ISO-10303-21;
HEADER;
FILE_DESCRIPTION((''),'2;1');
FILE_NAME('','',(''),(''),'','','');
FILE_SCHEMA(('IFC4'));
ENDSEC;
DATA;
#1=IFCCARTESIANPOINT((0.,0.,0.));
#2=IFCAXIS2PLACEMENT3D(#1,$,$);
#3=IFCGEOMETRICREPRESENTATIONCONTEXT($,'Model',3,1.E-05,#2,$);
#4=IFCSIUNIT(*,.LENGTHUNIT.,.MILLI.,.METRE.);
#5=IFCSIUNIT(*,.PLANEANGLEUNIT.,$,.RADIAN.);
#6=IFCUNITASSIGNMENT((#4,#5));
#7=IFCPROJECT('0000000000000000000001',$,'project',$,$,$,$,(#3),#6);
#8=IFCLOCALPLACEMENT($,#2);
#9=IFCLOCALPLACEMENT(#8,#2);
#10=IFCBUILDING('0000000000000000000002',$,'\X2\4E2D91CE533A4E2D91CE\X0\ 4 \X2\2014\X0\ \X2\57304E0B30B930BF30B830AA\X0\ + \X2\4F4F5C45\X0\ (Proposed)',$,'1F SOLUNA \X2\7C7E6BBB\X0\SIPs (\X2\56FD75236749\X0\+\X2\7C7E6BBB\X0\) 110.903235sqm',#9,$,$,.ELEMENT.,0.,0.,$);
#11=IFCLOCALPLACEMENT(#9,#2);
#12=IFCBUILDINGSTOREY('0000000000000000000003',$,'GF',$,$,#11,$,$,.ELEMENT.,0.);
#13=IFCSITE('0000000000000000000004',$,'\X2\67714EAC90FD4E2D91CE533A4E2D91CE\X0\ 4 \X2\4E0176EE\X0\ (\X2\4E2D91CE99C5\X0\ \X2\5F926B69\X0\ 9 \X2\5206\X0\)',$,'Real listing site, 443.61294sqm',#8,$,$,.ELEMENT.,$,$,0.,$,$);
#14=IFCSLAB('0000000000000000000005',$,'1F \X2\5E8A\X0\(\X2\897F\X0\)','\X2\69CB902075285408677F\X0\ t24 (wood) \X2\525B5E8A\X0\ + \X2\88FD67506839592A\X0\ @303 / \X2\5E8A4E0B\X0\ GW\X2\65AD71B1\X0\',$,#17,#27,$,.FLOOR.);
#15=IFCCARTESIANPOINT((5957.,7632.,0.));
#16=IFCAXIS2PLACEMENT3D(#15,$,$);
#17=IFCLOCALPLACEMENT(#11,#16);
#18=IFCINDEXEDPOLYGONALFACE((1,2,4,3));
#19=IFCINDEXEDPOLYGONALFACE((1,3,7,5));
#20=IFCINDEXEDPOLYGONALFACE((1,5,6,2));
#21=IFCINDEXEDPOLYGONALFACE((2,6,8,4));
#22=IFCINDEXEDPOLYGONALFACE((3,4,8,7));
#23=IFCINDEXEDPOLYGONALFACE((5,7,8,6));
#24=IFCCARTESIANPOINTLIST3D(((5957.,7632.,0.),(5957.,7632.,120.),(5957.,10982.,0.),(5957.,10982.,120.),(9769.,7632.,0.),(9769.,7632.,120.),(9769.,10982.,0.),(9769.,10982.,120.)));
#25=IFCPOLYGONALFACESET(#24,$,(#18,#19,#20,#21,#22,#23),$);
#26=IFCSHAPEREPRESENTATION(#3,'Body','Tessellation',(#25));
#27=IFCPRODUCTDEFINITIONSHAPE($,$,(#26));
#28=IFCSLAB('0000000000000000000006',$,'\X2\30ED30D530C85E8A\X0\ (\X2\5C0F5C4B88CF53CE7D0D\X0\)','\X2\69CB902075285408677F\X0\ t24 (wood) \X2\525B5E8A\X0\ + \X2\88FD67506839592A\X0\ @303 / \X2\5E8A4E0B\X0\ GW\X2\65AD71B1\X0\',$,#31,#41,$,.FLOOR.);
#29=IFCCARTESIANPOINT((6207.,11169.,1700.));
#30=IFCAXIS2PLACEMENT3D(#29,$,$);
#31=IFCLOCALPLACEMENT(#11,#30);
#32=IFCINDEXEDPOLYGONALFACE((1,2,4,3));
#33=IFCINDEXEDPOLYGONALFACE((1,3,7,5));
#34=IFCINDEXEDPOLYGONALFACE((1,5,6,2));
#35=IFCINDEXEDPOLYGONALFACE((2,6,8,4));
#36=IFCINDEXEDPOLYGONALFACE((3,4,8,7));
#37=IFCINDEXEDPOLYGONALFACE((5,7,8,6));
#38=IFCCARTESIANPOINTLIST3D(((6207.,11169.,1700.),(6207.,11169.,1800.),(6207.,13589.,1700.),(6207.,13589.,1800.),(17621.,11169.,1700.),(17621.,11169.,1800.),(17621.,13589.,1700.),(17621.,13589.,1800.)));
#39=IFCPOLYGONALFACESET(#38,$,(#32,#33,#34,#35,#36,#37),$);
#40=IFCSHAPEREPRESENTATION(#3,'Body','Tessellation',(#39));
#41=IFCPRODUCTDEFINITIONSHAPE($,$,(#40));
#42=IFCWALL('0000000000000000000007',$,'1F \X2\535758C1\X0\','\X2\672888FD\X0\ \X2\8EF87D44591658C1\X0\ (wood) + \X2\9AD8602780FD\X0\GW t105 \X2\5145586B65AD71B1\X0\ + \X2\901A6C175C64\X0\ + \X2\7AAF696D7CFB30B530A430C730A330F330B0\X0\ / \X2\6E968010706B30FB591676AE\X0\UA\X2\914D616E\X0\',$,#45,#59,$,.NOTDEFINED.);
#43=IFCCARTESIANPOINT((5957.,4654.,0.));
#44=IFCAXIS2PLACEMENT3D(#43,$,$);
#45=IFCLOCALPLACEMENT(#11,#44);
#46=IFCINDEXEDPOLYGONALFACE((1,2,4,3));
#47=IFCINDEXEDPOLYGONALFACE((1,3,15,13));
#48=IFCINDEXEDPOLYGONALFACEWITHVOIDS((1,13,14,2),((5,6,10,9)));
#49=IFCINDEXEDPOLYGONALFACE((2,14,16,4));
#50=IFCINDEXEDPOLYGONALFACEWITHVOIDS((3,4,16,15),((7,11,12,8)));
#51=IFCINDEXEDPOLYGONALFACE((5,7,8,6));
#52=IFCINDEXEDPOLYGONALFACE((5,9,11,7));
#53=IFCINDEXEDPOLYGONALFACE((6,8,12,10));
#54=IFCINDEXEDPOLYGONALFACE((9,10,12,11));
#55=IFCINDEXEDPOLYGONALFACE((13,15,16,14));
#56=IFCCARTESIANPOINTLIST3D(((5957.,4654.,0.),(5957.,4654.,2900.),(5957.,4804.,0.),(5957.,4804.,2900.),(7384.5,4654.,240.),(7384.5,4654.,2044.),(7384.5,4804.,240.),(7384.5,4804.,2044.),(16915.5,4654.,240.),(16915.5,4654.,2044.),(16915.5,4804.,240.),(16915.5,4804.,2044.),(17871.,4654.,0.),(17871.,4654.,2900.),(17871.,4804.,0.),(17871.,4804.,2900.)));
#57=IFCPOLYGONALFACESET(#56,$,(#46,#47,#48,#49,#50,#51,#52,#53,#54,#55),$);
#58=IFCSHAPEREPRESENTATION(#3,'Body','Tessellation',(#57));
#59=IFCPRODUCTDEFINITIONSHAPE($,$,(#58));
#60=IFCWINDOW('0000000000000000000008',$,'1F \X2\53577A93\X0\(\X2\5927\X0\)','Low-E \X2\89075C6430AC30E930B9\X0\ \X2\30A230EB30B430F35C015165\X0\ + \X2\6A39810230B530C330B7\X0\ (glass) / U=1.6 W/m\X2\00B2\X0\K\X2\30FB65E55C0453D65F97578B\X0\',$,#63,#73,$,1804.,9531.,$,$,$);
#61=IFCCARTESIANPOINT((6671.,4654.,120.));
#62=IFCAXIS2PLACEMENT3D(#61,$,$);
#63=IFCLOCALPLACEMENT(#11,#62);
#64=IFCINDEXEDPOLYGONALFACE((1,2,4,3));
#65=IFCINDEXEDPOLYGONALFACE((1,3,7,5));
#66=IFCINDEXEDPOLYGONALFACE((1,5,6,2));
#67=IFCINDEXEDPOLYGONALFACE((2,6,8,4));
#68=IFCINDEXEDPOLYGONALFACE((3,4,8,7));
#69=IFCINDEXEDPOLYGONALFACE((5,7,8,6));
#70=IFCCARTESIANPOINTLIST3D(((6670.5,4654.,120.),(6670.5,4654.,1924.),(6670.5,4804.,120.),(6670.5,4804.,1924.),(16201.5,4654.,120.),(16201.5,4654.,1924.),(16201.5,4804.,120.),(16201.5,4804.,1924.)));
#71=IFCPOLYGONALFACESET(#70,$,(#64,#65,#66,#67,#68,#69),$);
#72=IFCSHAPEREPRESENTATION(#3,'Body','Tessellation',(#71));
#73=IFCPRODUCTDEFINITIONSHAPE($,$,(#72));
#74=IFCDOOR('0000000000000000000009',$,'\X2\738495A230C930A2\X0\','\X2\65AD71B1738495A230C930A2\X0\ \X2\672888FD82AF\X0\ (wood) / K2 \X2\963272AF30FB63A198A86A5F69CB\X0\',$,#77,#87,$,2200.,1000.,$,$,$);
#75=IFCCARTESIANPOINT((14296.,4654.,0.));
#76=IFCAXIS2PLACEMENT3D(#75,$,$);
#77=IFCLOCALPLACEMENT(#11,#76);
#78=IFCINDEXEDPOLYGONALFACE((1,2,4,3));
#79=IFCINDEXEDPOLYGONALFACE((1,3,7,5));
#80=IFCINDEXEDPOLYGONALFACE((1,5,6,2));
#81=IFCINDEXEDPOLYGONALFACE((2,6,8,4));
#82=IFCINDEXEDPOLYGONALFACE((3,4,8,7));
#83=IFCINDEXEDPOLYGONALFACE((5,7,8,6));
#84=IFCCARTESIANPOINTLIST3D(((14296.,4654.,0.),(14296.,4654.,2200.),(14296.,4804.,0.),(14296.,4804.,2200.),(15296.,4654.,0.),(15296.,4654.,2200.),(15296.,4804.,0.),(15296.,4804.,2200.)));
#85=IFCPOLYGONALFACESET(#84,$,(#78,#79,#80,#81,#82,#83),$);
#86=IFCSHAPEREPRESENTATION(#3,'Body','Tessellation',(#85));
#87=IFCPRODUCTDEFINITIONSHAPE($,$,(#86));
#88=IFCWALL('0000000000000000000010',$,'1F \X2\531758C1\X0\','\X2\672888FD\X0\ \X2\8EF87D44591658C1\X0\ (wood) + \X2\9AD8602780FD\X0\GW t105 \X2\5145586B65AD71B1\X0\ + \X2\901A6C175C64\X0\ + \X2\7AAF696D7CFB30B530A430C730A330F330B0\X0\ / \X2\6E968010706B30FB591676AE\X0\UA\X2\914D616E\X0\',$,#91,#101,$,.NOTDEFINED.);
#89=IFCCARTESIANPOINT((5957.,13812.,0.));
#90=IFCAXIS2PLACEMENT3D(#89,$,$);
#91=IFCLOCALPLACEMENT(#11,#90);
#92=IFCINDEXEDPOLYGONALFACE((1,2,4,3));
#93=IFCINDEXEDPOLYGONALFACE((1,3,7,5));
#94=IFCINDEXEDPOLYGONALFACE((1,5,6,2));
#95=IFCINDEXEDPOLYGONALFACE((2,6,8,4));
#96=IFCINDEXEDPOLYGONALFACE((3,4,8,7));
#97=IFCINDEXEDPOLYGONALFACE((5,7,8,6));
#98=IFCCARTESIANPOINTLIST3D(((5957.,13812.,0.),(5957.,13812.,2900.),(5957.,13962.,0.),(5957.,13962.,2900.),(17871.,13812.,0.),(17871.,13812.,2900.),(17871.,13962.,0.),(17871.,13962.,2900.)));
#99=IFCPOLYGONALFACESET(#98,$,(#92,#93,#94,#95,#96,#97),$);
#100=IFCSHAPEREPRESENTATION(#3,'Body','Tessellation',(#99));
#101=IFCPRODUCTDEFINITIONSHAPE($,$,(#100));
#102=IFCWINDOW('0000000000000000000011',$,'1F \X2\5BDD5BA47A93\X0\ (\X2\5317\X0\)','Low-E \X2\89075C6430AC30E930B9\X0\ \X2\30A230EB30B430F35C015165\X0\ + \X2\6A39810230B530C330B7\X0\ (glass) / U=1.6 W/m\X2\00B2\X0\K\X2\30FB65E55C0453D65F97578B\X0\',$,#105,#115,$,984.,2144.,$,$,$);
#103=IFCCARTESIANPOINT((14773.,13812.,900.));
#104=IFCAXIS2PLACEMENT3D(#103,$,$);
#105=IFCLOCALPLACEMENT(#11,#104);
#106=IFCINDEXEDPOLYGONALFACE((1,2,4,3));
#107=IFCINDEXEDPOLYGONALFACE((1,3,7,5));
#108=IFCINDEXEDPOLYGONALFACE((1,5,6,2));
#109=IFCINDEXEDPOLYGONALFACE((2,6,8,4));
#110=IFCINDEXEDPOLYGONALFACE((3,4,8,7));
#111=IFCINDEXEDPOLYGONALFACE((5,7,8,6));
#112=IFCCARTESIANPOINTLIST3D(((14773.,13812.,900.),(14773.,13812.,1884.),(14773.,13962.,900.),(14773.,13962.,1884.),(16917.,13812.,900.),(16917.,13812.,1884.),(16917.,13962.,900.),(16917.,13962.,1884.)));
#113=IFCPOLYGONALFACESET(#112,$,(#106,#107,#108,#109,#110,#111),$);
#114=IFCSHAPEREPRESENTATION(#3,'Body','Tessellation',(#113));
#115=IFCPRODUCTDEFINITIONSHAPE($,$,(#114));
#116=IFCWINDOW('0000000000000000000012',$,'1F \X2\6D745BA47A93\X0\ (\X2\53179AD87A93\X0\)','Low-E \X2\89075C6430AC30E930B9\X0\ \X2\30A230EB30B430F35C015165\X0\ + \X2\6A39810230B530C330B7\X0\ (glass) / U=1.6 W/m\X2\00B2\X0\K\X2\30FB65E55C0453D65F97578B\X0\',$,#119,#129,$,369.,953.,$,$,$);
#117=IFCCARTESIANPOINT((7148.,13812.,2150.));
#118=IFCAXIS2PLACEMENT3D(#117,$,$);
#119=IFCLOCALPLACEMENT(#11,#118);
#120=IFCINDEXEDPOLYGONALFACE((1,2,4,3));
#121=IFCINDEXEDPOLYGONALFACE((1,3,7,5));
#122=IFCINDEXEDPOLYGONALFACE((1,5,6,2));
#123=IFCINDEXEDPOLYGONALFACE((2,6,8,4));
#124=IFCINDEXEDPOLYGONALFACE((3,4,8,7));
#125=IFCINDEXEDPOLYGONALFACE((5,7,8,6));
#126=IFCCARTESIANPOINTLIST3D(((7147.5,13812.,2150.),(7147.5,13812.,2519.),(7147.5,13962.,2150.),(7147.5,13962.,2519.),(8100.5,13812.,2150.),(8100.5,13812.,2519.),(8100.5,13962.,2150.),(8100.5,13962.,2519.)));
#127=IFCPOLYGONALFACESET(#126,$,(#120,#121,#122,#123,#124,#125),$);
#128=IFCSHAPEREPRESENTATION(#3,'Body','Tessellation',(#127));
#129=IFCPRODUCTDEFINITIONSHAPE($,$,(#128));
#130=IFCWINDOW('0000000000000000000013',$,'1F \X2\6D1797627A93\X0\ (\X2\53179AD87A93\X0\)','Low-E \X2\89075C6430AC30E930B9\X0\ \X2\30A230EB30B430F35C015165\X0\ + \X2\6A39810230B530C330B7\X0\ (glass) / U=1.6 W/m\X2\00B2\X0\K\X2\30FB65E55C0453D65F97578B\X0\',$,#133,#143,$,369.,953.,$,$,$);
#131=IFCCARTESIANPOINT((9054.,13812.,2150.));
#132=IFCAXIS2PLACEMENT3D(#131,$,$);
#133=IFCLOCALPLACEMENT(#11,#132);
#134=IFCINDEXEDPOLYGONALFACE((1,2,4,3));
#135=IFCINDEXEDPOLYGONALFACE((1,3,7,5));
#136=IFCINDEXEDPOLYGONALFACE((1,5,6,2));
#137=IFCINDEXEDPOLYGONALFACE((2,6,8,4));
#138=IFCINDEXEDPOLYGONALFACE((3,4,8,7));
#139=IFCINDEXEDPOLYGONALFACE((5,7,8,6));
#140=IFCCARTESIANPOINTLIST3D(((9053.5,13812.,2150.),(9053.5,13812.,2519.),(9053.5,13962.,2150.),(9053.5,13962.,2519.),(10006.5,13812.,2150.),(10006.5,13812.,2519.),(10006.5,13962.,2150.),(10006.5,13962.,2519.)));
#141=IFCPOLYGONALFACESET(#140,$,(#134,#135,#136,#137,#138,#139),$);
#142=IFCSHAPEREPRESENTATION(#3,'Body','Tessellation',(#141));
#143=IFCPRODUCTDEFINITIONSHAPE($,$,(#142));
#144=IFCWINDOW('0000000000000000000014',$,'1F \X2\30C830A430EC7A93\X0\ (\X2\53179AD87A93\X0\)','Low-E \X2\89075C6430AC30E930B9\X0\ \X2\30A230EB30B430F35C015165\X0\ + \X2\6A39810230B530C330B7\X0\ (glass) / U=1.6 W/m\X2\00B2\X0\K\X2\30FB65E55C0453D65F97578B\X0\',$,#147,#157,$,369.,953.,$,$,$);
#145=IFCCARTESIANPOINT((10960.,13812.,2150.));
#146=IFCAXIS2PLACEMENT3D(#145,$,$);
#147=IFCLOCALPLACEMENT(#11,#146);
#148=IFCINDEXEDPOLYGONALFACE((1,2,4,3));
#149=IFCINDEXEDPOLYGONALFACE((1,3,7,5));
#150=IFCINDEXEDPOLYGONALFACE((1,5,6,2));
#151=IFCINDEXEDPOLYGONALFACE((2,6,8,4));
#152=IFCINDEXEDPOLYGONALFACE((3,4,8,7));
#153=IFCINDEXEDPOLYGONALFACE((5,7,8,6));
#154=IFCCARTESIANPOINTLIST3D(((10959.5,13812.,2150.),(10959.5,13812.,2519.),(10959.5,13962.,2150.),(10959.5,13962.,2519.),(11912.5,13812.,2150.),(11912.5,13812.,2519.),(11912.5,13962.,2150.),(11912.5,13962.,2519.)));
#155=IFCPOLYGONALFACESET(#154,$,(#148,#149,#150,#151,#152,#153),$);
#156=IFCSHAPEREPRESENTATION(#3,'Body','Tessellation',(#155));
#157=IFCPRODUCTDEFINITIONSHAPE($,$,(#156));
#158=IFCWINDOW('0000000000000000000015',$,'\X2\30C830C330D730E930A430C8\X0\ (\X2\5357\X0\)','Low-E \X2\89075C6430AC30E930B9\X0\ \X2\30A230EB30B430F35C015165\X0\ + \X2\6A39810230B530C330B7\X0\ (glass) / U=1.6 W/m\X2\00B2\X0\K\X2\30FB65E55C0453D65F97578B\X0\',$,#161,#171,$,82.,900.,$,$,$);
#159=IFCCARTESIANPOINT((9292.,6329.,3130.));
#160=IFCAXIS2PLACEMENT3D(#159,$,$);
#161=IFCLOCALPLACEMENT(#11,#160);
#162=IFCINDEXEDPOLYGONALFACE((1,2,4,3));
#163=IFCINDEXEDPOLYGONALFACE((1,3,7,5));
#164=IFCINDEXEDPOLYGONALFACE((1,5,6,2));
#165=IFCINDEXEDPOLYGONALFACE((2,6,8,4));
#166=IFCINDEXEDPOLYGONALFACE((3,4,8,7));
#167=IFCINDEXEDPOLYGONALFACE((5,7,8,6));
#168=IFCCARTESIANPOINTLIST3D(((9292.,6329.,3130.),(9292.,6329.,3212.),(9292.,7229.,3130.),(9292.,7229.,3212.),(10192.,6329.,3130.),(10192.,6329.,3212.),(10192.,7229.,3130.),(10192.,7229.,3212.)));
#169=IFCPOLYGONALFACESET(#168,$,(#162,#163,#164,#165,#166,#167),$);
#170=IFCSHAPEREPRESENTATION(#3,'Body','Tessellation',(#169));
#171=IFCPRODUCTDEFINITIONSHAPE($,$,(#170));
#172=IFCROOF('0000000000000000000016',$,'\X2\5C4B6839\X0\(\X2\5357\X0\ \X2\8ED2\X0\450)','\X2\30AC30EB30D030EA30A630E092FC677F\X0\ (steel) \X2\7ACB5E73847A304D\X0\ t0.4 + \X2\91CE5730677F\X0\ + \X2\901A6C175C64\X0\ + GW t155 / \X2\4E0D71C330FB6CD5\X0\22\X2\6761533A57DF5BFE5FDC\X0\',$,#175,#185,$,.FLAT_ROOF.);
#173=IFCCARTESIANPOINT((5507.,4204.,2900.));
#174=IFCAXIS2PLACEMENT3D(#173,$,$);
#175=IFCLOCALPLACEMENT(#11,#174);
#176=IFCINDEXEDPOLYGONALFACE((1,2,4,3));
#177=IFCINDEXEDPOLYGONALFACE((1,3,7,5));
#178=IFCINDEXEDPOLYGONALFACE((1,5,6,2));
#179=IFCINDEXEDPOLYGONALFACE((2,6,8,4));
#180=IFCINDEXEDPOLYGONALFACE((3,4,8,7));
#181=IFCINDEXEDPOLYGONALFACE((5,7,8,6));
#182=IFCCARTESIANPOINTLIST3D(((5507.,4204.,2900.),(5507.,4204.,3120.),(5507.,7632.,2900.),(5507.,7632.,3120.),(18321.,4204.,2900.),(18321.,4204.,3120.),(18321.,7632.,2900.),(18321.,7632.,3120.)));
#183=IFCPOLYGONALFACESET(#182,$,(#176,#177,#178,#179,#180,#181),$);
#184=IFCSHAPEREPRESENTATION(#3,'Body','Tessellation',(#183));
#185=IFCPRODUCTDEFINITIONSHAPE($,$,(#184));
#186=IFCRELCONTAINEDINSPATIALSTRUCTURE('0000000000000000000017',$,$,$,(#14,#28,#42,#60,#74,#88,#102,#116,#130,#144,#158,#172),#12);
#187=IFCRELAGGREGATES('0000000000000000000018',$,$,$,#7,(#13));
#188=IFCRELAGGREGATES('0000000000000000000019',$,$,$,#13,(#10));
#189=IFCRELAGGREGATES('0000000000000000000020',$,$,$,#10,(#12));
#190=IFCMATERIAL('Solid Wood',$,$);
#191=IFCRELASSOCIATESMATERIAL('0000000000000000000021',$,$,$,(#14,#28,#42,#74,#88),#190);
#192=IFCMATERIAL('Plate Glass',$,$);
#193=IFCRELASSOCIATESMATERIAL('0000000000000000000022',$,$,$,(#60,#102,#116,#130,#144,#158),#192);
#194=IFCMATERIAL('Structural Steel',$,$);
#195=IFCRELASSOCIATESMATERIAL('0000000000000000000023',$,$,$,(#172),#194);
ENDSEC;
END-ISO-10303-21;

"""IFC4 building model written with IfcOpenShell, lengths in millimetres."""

from ifc_helpers import new_model, si_unit, frame, frame_2d, origin, place, context, project, spatial, rectangle, extrude, material, element, fill, save


model = new_model("IFC4")

# Units and contexts
model_context = context("Model", 3, precision=1e-05, world=origin())
ifc_project = project(units=[si_unit("LENGTHUNIT", "METRE", prefix="MILLI"), si_unit("PLANEANGLEUNIT", "RADIAN")], contexts=[model_context])

# Site, building, storey
site_placement = place(None, origin())
site = spatial("IfcSite", under=ifc_project, at=site_placement, Name="東京都中野区中野 4 丁目 (中野駅 徒歩 9 分)", ObjectType="Real listing site, 443.61294sqm", CompositionType="ELEMENT", RefElevation=0.0)
building_placement = place(site_placement, origin())
building = spatial("IfcBuilding", under=site, at=building_placement, Name="中野区中野 4 — 地下スタジオ + 住居 (Proposed)", ObjectType="1F SOLUNA 籾殻SIPs (国産杉+籾殻) 110.903235sqm", CompositionType="ELEMENT", ElevationOfRefHeight=0.0, ElevationOfTerrain=0.0)
storey_placement = place(building_placement, origin())
storey = spatial("IfcBuildingStorey", under=building, at=storey_placement, Name="GF", CompositionType="ELEMENT", Elevation=0.0)

# Slabs
ifc_material_1 = material(Name="Solid Wood")
slab_1_placement = place(storey_placement, frame((5957.0, 7632.0, 0.0)))
element("IfcSlab", 1, at=slab_1_placement, inside=storey, material=ifc_material_1, Name="1F 床(西)", Description="構造用合板 t24 (wood) 剛床 + 製材根太 @303 / 床下 GW断熱", PredefinedType="FLOOR", context=model_context, shape_type="SweptSolid", body=[
    extrude(rectangle(XDim=3812.0, YDim=3350.0, at=frame_2d((1906.0, 1675.0))), frame((5957.0, 7632.0, 0.0)), (0.0, 0.0, 1.0), 120.0),
])
slab_2_placement = place(storey_placement, frame((6207.0, 11169.0, 1700.0)))
element("IfcSlab", 2, at=slab_2_placement, inside=storey, material=ifc_material_1, Name="ロフト床 (小屋裏収納)", Description="構造用合板 t24 (wood) 剛床 + 製材根太 @303 / 床下 GW断熱", PredefinedType="FLOOR", context=model_context, shape_type="SweptSolid", body=[
    extrude(rectangle(XDim=11414.0, YDim=2420.0, at=frame_2d((5707.0, 1210.0))), frame((6207.0, 11169.0, 1700.0)), (0.0, 0.0, 1.0), 100.0),
])

# Wall, openings, window, door
wall_1_placement = place(storey_placement, frame((5957.0, 4654.0, 0.0)))
wall_1 = element("IfcWall", 3, at=wall_1_placement, inside=storey, material=ifc_material_1, Name="1F 南壁", Description="木製 軸組外壁 (wood) + 高性能GW t105 充填断熱 + 通気層 + 窯業系サイディング / 準耐火・外皮UA配慮", PredefinedType="NOTDEFINED", context=model_context, shape_type="SweptSolid", body=[
    extrude(rectangle(XDim=11914.0, YDim=150.0, at=frame_2d((5957.0, 75.0))), frame((5957.0, 4654.0, 0.0)), (0.0, 0.0, 1.0), 2900.0),
])
opening_1_placement = place(storey_placement, frame((6671.0, 4654.0, 120.0)))
opening_1 = element("IfcOpeningElement", 4, at=opening_1_placement, cuts=wall_1, PredefinedType="NOTDEFINED", context=model_context, shape_type="SweptSolid", body=[
    extrude(rectangle(XDim=9531.0, YDim=150.0, at=frame_2d((4765.0, 75.0))), frame((6671.0, 4654.0, 120.0)), (0.0, 0.0, 1.0), 1804.0),
])
opening_2_placement = place(storey_placement, frame((14296.0, 4654.0, 0.0)))
opening_2 = element("IfcOpeningElement", 5, at=opening_2_placement, cuts=wall_1, PredefinedType="NOTDEFINED", context=model_context, shape_type="SweptSolid", body=[
    extrude(rectangle(XDim=1000.0, YDim=150.0, at=frame_2d((500.0, 75.0))), frame((14296.0, 4654.0, 0.0)), (0.0, 0.0, 1.0), 2200.0),
])
ifc_material_2 = material(Name="Plate Glass")
window_1_placement = place(storey_placement, frame((6671.0, 4654.0, 120.0)))
window_1 = element("IfcWindow", 6, at=window_1_placement, inside=storey, material=ifc_material_2, Name="1F 南窓(大)", Description="Low-E 複層ガラス アルゴン封入 + 樹脂サッシ (glass) / U=1.6 W/m²K・日射取得型", OverallHeight=1804.0, OverallWidth=9531.0, context=model_context, shape_type="SweptSolid", body=[
    extrude(rectangle(XDim=9531.0, YDim=150.0, at=frame_2d((4765.0, 75.0))), frame((6671.0, 4654.0, 120.0)), (0.0, 0.0, 1.0), 1804.0),
])
fill(opening_1, window_1)
door_1_placement = place(storey_placement, frame((14296.0, 4654.0, 0.0)))
door_1 = element("IfcDoor", 7, at=door_1_placement, inside=storey, material=ifc_material_1, Name="玄関ドア", Description="断熱玄関ドア 木製芯 (wood) / K2 防犯・採風機構", OverallHeight=2200.0, OverallWidth=1000.0, context=model_context, shape_type="SweptSolid", body=[
    extrude(rectangle(XDim=1000.0, YDim=150.0, at=frame_2d((500.0, 75.0))), frame((14296.0, 4654.0, 0.0)), (0.0, 0.0, 1.0), 2200.0),
])
fill(opening_2, door_1)

# Wall, openings, windows
wall_2_placement = place(storey_placement, frame((5957.0, 13812.0, 0.0)))
wall_2 = element("IfcWall", 8, at=wall_2_placement, inside=storey, material=ifc_material_1, Name="1F 北壁", Description="木製 軸組外壁 (wood) + 高性能GW t105 充填断熱 + 通気層 + 窯業系サイディング / 準耐火・外皮UA配慮", PredefinedType="NOTDEFINED", context=model_context, shape_type="SweptSolid", body=[
    extrude(rectangle(XDim=11914.0, YDim=150.0, at=frame_2d((5957.0, 75.0))), frame((5957.0, 13812.0, 0.0)), (0.0, 0.0, 1.0), 2900.0),
])
opening_3_placement = place(storey_placement, frame((14773.0, 13812.0, 900.0)))
opening_3 = element("IfcOpeningElement", 9, at=opening_3_placement, cuts=wall_2, PredefinedType="NOTDEFINED", context=model_context, shape_type="SweptSolid", body=[
    extrude(rectangle(XDim=2144.0, YDim=150.0, at=frame_2d((1072.0, 75.0))), frame((14773.0, 13812.0, 900.0)), (0.0, 0.0, 1.0), 984.0),
])
opening_4_placement = place(storey_placement, frame((7148.0, 13812.0, 2150.0)))
opening_4 = element("IfcOpeningElement", 10, at=opening_4_placement, cuts=wall_2, PredefinedType="NOTDEFINED", context=model_context, shape_type="SweptSolid", body=[
    extrude(rectangle(XDim=953.0, YDim=150.0, at=frame_2d((476.0, 75.0))), frame((7148.0, 13812.0, 2150.0)), (0.0, 0.0, 1.0), 369.0),
])
opening_5_placement = place(storey_placement, frame((9054.0, 13812.0, 2150.0)))
opening_5 = element("IfcOpeningElement", 11, at=opening_5_placement, cuts=wall_2, PredefinedType="NOTDEFINED", context=model_context, shape_type="SweptSolid", body=[
    extrude(rectangle(XDim=953.0, YDim=150.0, at=frame_2d((476.0, 75.0))), frame((9054.0, 13812.0, 2150.0)), (0.0, 0.0, 1.0), 369.0),
])
opening_6_placement = place(storey_placement, frame((10960.0, 13812.0, 2150.0)))
opening_6 = element("IfcOpeningElement", 12, at=opening_6_placement, cuts=wall_2, PredefinedType="NOTDEFINED", context=model_context, shape_type="SweptSolid", body=[
    extrude(rectangle(XDim=953.0, YDim=150.0, at=frame_2d((476.0, 75.0))), frame((10960.0, 13812.0, 2150.0)), (0.0, 0.0, 1.0), 369.0),
])
window_2_placement = place(storey_placement, frame((14773.0, 13812.0, 900.0)))
window_2 = element("IfcWindow", 13, at=window_2_placement, inside=storey, material=ifc_material_2, Name="1F 寝室窓 (北)", Description="Low-E 複層ガラス アルゴン封入 + 樹脂サッシ (glass) / U=1.6 W/m²K・日射取得型", OverallHeight=984.0, OverallWidth=2144.0, context=model_context, shape_type="SweptSolid", body=[
    extrude(rectangle(XDim=2144.0, YDim=150.0, at=frame_2d((1072.0, 75.0))), frame((14773.0, 13812.0, 900.0)), (0.0, 0.0, 1.0), 984.0),
])
fill(opening_3, window_2)
window_3_placement = place(storey_placement, frame((7148.0, 13812.0, 2150.0)))
window_3 = element("IfcWindow", 14, at=window_3_placement, inside=storey, material=ifc_material_2, Name="1F 浴室窓 (北高窓)", Description="Low-E 複層ガラス アルゴン封入 + 樹脂サッシ (glass) / U=1.6 W/m²K・日射取得型", OverallHeight=369.0, OverallWidth=953.0, context=model_context, shape_type="SweptSolid", body=[
    extrude(rectangle(XDim=953.0, YDim=150.0, at=frame_2d((476.0, 75.0))), frame((7148.0, 13812.0, 2150.0)), (0.0, 0.0, 1.0), 369.0),
])
fill(opening_4, window_3)
window_4_placement = place(storey_placement, frame((9054.0, 13812.0, 2150.0)))
window_4 = element("IfcWindow", 15, at=window_4_placement, inside=storey, material=ifc_material_2, Name="1F 洗面窓 (北高窓)", Description="Low-E 複層ガラス アルゴン封入 + 樹脂サッシ (glass) / U=1.6 W/m²K・日射取得型", OverallHeight=369.0, OverallWidth=953.0, context=model_context, shape_type="SweptSolid", body=[
    extrude(rectangle(XDim=953.0, YDim=150.0, at=frame_2d((476.0, 75.0))), frame((9054.0, 13812.0, 2150.0)), (0.0, 0.0, 1.0), 369.0),
])
fill(opening_5, window_4)
window_5_placement = place(storey_placement, frame((10960.0, 13812.0, 2150.0)))
window_5 = element("IfcWindow", 16, at=window_5_placement, inside=storey, material=ifc_material_2, Name="1F トイレ窓 (北高窓)", Description="Low-E 複層ガラス アルゴン封入 + 樹脂サッシ (glass) / U=1.6 W/m²K・日射取得型", OverallHeight=369.0, OverallWidth=953.0, context=model_context, shape_type="SweptSolid", body=[
    extrude(rectangle(XDim=953.0, YDim=150.0, at=frame_2d((476.0, 75.0))), frame((10960.0, 13812.0, 2150.0)), (0.0, 0.0, 1.0), 369.0),
])
fill(opening_6, window_5)

# Window
window_6_placement = place(storey_placement, frame((9292.0, 6329.0, 3130.0)))
element("IfcWindow", 17, at=window_6_placement, inside=storey, material=ifc_material_2, Name="トップライト (南)", Description="Low-E 複層ガラス アルゴン封入 + 樹脂サッシ (glass) / U=1.6 W/m²K・日射取得型", OverallHeight=82.0, OverallWidth=900.0, context=model_context, shape_type="SweptSolid", body=[
    extrude(rectangle(XDim=900.0, YDim=900.0, at=frame_2d((450.0, 450.0))), frame((9292.0, 6329.0, 3130.0)), (0.0, 0.0, 1.0), 82.0),
])

# Roof
ifc_material_3 = material(Name="Structural Steel")
roof_1_placement = place(storey_placement, frame((5507.0, 4204.0, 2900.0)))
element("IfcRoof", 18, at=roof_1_placement, inside=storey, material=ifc_material_3, Name="屋根(南 軒450)", Description="ガルバリウム鋼板 (steel) 立平葺き t0.4 + 野地板 + 通気層 + GW t155 / 不燃・法22条区域対応", PredefinedType="FLAT_ROOF", context=model_context, shape_type="SweptSolid", body=[
    extrude(rectangle(XDim=12814.0, YDim=3428.0, at=frame_2d((6407.0, 1714.0))), frame((5507.0, 4204.0, 2900.0)), (0.0, 0.0, 1.0), 220.0),
])

save(model, "model.ifc")
